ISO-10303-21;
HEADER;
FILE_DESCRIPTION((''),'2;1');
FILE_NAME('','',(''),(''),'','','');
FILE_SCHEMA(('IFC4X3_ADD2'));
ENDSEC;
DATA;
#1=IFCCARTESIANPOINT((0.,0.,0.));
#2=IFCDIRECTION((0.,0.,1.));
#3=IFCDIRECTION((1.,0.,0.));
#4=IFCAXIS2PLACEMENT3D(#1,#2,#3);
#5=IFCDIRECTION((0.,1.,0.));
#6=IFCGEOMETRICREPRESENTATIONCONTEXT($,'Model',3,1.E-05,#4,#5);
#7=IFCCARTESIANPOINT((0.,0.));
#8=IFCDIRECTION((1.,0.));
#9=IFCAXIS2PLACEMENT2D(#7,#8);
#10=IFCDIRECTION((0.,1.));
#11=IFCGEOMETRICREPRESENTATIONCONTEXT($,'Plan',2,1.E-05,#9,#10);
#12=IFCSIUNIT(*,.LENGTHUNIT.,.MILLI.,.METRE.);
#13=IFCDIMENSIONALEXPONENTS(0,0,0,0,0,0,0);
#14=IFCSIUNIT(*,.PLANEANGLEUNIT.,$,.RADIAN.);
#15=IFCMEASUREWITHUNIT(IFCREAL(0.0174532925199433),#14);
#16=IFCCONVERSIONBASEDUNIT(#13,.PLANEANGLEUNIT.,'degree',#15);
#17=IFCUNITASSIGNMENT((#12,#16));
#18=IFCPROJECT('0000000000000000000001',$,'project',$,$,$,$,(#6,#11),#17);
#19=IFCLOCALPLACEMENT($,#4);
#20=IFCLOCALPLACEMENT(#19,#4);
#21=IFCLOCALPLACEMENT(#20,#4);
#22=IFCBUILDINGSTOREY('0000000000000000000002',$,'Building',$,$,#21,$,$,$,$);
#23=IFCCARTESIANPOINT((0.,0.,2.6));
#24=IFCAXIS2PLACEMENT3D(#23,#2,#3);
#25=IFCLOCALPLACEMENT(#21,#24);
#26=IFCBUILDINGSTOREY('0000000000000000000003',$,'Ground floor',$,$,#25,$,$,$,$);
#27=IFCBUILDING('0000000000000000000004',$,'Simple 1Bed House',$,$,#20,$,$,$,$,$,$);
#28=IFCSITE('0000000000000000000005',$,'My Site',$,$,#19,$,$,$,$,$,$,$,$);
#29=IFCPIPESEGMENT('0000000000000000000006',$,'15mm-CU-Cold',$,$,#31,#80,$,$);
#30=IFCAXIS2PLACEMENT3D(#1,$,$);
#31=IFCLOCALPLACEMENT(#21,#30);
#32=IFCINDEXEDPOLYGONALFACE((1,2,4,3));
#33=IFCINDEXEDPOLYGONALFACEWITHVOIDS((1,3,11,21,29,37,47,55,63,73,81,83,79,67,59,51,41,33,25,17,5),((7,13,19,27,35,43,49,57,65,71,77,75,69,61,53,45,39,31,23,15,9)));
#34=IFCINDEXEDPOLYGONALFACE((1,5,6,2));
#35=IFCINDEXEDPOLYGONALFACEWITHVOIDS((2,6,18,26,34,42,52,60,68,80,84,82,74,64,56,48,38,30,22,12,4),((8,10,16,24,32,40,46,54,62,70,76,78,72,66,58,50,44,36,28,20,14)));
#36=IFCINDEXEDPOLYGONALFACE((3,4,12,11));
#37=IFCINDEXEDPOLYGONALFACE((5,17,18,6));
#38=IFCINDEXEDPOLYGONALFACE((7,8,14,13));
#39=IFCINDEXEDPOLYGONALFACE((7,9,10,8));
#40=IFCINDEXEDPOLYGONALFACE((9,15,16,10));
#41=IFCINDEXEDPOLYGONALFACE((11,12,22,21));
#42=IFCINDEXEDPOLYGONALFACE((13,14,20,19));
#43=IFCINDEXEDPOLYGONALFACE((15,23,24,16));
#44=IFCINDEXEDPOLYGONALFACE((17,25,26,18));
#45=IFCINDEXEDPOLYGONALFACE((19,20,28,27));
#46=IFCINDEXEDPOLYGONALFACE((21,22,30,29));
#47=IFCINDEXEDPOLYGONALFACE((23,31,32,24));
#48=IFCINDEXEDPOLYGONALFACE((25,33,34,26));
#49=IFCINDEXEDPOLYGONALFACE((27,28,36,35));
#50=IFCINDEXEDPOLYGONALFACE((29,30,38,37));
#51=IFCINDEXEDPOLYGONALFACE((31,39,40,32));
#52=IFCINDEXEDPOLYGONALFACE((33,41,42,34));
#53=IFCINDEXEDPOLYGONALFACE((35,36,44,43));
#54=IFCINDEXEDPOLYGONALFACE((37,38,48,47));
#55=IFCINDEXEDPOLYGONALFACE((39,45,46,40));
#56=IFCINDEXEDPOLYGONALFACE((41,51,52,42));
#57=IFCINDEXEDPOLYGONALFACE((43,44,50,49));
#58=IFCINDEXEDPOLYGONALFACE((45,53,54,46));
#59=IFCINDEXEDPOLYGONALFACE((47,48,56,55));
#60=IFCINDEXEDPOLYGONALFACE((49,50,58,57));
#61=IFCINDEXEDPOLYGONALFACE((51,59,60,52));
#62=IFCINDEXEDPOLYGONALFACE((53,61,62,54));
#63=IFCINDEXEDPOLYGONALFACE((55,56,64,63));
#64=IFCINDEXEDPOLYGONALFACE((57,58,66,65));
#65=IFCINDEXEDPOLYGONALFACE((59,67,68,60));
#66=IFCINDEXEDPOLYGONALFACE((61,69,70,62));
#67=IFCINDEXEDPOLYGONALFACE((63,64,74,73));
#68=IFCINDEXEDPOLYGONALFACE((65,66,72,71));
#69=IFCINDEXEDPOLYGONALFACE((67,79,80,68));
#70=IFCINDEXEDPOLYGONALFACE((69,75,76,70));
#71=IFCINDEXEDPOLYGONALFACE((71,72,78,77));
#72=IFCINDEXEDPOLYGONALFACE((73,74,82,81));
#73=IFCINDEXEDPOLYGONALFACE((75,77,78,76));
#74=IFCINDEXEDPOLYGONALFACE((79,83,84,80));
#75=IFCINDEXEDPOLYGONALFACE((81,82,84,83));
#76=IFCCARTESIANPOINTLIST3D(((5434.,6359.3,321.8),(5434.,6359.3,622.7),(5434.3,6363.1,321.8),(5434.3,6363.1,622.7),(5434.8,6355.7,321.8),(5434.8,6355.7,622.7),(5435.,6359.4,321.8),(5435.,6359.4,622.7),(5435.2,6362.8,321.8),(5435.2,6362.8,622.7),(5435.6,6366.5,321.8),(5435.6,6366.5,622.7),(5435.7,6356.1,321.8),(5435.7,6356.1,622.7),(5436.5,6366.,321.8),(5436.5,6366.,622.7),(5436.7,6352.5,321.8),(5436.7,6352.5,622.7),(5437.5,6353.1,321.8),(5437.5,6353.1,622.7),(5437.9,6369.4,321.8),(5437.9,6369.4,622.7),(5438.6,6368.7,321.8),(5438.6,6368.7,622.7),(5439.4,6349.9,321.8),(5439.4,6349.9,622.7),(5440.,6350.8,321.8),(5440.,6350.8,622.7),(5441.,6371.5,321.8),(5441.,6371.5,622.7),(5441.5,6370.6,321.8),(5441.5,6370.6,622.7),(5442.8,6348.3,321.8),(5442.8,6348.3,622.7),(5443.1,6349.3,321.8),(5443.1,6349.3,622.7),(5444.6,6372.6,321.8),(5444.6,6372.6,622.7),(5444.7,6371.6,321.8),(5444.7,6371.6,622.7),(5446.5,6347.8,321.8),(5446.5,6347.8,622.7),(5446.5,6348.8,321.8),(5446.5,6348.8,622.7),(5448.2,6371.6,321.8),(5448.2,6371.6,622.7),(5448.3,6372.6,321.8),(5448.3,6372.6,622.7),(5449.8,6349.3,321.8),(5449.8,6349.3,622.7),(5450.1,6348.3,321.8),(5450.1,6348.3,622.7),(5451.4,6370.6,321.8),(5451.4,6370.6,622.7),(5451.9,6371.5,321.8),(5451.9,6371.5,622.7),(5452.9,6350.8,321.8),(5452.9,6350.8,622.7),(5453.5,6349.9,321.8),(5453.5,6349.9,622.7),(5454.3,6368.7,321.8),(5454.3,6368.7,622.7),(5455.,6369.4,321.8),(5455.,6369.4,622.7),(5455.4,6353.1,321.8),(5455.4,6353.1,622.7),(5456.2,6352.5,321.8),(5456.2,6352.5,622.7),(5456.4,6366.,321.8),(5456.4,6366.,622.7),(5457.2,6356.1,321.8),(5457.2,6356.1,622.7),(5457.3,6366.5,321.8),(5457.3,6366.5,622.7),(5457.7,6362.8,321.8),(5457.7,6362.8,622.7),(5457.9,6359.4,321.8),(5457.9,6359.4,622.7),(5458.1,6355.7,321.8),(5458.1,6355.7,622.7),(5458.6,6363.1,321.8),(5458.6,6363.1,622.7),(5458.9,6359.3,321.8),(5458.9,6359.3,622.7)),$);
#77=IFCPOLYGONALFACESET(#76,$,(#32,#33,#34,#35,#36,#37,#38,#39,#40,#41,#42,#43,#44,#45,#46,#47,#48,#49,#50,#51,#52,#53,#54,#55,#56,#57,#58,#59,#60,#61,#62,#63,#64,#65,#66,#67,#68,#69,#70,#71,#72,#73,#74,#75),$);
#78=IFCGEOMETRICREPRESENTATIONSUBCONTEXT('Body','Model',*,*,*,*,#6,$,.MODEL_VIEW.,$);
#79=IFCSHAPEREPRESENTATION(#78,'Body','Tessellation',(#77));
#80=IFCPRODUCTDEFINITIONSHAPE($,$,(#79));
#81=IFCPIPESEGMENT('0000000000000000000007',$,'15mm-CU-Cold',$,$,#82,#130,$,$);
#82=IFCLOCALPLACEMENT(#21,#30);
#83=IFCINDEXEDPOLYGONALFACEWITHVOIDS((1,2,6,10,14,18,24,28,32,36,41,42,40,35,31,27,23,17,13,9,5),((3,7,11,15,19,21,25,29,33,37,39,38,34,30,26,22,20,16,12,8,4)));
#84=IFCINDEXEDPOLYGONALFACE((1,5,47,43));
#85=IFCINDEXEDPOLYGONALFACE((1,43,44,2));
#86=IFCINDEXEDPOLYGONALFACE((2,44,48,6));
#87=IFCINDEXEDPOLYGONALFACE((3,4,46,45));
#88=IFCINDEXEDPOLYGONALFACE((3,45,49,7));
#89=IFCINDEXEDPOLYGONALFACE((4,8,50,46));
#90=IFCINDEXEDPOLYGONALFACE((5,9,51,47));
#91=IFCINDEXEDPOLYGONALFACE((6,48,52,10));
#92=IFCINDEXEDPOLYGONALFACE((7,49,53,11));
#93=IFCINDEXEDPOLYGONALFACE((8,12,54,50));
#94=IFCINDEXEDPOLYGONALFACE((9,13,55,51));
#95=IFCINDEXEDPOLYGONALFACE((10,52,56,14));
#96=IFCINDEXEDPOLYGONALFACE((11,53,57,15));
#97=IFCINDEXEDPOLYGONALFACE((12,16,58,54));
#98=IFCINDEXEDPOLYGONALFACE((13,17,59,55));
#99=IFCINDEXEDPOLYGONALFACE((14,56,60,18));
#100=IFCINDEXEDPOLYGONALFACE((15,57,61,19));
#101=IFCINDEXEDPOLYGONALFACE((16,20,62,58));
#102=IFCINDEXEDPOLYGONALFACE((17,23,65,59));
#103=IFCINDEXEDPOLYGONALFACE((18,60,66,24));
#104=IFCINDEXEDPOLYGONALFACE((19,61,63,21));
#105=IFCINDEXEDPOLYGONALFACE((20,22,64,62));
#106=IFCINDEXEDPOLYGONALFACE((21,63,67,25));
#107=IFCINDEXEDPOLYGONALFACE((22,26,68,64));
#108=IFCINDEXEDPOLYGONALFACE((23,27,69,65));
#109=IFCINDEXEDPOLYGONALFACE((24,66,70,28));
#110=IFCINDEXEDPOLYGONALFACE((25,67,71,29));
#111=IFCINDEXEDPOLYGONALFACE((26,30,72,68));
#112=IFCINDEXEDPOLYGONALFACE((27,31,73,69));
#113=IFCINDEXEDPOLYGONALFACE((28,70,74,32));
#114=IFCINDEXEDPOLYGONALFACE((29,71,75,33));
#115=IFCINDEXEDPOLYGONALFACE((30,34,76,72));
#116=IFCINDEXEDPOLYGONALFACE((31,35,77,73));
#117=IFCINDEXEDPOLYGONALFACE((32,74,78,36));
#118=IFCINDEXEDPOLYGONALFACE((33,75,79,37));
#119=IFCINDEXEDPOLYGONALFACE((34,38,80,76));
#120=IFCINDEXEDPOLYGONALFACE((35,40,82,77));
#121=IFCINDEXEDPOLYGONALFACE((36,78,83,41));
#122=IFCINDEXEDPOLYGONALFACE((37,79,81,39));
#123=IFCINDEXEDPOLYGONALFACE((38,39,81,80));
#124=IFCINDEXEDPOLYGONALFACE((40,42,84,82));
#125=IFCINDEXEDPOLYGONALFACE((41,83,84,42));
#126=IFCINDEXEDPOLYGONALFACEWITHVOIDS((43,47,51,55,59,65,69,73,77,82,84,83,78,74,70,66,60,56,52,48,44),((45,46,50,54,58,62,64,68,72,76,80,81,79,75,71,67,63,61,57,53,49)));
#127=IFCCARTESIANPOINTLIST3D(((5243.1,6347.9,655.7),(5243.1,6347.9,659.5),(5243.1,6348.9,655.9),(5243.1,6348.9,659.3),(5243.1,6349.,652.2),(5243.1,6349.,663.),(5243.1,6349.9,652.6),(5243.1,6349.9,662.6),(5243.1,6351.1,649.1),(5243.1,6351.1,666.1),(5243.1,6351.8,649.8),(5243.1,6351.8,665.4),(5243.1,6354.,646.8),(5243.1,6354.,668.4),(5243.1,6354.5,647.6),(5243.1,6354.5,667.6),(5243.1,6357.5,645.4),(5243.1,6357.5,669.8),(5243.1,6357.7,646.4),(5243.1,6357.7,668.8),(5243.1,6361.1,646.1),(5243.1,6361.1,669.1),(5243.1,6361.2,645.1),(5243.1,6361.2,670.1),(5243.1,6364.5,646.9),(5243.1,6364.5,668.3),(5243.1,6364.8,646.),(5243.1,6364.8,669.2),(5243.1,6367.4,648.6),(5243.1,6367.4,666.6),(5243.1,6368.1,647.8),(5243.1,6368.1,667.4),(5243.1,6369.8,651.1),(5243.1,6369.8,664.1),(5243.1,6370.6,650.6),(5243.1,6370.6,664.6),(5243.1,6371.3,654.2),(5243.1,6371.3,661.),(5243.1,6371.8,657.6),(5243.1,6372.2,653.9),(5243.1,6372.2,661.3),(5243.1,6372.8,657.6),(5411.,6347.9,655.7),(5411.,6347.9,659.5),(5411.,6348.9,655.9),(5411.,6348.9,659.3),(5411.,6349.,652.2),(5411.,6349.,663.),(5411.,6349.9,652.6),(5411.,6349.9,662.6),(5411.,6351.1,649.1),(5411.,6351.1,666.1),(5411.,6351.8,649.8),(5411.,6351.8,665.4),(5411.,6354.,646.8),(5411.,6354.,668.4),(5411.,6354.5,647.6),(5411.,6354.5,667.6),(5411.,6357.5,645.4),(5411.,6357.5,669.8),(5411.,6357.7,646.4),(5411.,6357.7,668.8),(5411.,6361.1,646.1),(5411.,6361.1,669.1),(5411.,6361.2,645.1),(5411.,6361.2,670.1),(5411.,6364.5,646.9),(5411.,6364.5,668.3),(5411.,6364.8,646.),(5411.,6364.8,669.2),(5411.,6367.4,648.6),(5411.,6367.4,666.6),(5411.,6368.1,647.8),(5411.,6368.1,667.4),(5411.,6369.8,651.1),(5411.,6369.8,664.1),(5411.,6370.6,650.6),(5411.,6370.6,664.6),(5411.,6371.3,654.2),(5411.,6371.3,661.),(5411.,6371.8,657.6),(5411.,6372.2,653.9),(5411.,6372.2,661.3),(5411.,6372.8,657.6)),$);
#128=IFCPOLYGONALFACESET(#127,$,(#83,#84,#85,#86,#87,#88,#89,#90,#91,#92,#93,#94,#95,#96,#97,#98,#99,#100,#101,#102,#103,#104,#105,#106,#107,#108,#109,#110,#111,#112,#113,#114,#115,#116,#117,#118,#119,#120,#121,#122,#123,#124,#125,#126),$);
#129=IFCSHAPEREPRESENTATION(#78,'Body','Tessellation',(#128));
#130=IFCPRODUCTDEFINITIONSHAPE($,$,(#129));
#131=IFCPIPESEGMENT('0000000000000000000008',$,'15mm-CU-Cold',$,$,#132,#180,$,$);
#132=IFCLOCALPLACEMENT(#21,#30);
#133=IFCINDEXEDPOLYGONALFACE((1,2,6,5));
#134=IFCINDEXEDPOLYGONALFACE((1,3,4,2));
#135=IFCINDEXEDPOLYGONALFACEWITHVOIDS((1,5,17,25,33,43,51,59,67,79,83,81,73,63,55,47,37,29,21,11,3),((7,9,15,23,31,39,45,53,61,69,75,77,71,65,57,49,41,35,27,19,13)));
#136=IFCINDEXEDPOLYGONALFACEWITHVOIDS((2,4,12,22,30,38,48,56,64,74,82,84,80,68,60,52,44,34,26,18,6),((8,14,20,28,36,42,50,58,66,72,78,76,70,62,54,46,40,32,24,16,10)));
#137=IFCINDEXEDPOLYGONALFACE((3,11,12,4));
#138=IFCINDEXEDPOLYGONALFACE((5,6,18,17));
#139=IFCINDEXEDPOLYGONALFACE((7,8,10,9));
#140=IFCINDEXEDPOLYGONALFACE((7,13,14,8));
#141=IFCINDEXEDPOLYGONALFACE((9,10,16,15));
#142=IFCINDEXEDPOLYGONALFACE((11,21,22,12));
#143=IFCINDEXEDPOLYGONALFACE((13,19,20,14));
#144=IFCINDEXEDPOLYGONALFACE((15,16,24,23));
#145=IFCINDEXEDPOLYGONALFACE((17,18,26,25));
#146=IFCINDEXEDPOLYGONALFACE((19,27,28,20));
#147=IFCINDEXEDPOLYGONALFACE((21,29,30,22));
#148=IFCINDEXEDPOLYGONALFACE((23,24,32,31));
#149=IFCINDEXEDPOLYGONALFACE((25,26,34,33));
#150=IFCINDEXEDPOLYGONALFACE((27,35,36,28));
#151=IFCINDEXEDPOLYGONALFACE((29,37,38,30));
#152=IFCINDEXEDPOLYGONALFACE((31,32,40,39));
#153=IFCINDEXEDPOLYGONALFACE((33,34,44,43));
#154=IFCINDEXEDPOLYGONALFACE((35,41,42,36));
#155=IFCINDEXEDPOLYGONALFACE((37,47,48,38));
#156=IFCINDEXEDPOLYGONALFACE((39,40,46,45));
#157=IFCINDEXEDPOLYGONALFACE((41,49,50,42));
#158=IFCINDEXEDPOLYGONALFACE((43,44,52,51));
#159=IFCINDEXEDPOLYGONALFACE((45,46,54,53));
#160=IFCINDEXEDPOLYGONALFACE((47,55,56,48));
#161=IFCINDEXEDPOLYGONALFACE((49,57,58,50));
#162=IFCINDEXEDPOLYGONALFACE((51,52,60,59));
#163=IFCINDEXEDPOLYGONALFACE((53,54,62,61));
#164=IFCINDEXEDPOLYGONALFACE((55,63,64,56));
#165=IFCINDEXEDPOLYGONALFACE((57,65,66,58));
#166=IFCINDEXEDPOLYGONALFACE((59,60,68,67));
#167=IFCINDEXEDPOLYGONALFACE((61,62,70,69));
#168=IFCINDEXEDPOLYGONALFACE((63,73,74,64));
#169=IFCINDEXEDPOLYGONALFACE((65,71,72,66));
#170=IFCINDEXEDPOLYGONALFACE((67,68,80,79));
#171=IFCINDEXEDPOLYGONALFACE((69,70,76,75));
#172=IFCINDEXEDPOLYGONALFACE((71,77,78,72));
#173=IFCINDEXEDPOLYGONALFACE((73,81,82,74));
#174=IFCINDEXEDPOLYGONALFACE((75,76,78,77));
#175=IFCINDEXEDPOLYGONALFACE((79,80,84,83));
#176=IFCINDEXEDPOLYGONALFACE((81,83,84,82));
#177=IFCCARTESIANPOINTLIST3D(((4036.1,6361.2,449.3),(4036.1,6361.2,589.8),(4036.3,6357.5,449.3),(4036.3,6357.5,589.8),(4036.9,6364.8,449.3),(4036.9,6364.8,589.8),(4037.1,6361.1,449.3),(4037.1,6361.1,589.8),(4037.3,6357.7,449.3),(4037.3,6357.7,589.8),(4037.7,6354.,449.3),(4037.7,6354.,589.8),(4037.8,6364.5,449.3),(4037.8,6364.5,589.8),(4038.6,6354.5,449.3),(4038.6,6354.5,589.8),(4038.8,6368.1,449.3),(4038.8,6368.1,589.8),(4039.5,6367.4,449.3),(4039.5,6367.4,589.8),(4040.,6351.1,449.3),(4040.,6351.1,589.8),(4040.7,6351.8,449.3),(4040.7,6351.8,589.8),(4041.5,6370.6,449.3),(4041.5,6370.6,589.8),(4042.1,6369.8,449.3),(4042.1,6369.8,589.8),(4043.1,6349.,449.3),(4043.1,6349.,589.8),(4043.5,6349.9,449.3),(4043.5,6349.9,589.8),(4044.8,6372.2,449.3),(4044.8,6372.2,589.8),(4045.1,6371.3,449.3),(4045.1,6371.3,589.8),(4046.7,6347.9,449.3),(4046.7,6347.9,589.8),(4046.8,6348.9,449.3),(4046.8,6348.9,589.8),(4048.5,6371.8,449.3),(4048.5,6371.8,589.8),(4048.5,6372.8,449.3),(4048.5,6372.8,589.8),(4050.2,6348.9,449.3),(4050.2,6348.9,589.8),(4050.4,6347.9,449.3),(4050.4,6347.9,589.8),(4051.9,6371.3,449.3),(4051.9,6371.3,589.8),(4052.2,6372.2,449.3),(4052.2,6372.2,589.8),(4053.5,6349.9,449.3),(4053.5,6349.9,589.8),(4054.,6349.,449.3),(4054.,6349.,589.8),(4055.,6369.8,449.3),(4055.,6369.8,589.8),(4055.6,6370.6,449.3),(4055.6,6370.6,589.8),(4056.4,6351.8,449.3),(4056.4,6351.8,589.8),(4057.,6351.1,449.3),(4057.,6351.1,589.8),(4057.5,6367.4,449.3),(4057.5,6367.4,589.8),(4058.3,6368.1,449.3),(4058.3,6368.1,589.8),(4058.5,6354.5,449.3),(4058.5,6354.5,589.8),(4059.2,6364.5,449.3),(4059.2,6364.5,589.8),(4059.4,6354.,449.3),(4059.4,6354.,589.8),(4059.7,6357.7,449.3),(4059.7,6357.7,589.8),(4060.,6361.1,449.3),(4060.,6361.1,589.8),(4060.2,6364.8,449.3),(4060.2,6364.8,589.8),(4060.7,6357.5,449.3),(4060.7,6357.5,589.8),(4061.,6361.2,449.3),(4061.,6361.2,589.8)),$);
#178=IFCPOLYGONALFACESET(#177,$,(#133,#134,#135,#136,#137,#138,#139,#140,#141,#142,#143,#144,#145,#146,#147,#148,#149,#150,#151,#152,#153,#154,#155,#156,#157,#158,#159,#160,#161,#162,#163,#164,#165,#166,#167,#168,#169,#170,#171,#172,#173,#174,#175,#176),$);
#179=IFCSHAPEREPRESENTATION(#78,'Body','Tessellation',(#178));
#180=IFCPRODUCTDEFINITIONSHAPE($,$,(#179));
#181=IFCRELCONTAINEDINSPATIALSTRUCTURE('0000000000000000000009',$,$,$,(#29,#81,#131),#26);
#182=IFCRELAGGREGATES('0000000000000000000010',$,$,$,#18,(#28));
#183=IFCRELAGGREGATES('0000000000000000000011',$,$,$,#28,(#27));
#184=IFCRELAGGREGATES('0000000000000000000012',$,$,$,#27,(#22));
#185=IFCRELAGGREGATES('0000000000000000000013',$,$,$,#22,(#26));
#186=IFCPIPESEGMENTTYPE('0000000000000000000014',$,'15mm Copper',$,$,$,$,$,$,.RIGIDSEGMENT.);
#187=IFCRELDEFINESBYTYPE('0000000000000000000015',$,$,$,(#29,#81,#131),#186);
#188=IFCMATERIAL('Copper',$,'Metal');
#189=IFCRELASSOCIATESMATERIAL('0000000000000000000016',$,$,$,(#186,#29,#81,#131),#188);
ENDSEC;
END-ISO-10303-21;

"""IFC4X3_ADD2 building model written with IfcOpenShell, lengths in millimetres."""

from ifc_helpers import new_model, entity, si_unit, converted_unit, direction, frame, origin_with_axes, origin_2d_with_axis, place, context, subcontext, project, spatial, hollow_circle, extrude, material, material_profile, profile_set, profile_usage, type_object, element, save


model = new_model("IFC4X3_ADD2")

# Units and contexts
model_context = context("Model", 3, precision=1e-05, world=origin_with_axes(), true_north=direction((0.0, 1.0, 0.0)))
plan_context = context("Plan", 2, precision=1e-05, world=origin_2d_with_axis(), true_north=direction((0.0, 1.0)))
body_context_1 = subcontext(model_context, "Body", "Model", "MODEL_VIEW")
ifc_project = project(units=[si_unit("LENGTHUNIT", "METRE", prefix="MILLI"), converted_unit("PLANEANGLEUNIT", "degree", entity("IfcReal", 0.0174532925199433), si_unit("PLANEANGLEUNIT", "RADIAN"), dimensions=[0, 0, 0, 0, 0, 0, 0])], contexts=[model_context, plan_context])

# Site, building, storeys
site_placement = place(None, origin_with_axes())
site = spatial("IfcSite", under=ifc_project, at=site_placement, Name="My Site")
building_placement = place(site_placement, origin_with_axes())
building = spatial("IfcBuilding", under=site, at=building_placement, Name="Simple 1Bed House")
storey_1_placement = place(building_placement, origin_with_axes())
storey_1 = spatial("IfcBuildingStorey", under=building, at=storey_1_placement, Name="Building")
storey_2_placement = place(storey_1_placement, frame((0.0, 0.0, 2.6), z_axis=(0.0, 0.0, 1.0), x_axis=(1.0, 0.0, 0.0)))
storey_2 = spatial("IfcBuildingStorey", under=storey_1, at=storey_2_placement, Name="Ground floor")

# Pipe segments
ifc_material_1 = material(Name="Copper", Category="Metal")
ifc_material_profile = material_profile(ifc_material_1, hollow_circle(Radius=12.5, WallThickness=1.0))
ifc_profile_set = profile_set([ifc_material_profile])
pipe_segment_type = type_object("IfcPipeSegmentType", Name="15mm Copper", PredefinedType="RIGIDSEGMENT", material=ifc_profile_set)
ifc_profile_usage_1 = profile_usage(ifc_profile_set, cardinal=5)
pipe_segment_1_placement = place(storey_2_placement, frame((5446.5, 6360.3, 319.2), z_axis=(0.0, 0.0, 1.0), x_axis=(0.0, -1.0, 0.0)))
element("IfcPipeSegment", 1, at=pipe_segment_1_placement, inside=storey_2, type_object=pipe_segment_type, material=ifc_profile_usage_1, Name="15mm-CU-Cold", context=body_context_1, shape_type="SweptSolid", body=[
    extrude(hollow_circle(Radius=12.5, WallThickness=1.0), origin_with_axes(), (0.0, 0.0, 1.0), 300.9),
])
ifc_profile_usage_2 = profile_usage(ifc_profile_set, cardinal=5)
pipe_segment_2_placement = place(storey_2_placement, frame((5243.1, 6360.3, 655.0), z_axis=(1.0, 0.0, 0.0), x_axis=(0.0, 1.0, 0.0)))
element("IfcPipeSegment", 2, at=pipe_segment_2_placement, inside=storey_2, type_object=pipe_segment_type, material=ifc_profile_usage_2, Name="15mm-CU-Cold", context=body_context_1, shape_type="SweptSolid", body=[
    extrude(hollow_circle(Radius=12.5, WallThickness=1.0), origin_with_axes(), (0.0, 0.0, 1.0), 167.8),
])
ifc_profile_usage_3 = profile_usage(ifc_profile_set, cardinal=5)
pipe_segment_3_placement = place(storey_2_placement, frame((4048.5, 6360.3, 587.2), z_axis=(0.0, 0.0, -1.0), x_axis=(0.0, 1.0, 0.0)))
element("IfcPipeSegment", 3, at=pipe_segment_3_placement, inside=storey_2, type_object=pipe_segment_type, material=ifc_profile_usage_3, Name="15mm-CU-Cold", context=body_context_1, shape_type="SweptSolid", body=[
    extrude(hollow_circle(Radius=12.5, WallThickness=1.0), origin_with_axes(), (0.0, 0.0, 1.0), 140.6),
])

save(model, "model.ifc")
